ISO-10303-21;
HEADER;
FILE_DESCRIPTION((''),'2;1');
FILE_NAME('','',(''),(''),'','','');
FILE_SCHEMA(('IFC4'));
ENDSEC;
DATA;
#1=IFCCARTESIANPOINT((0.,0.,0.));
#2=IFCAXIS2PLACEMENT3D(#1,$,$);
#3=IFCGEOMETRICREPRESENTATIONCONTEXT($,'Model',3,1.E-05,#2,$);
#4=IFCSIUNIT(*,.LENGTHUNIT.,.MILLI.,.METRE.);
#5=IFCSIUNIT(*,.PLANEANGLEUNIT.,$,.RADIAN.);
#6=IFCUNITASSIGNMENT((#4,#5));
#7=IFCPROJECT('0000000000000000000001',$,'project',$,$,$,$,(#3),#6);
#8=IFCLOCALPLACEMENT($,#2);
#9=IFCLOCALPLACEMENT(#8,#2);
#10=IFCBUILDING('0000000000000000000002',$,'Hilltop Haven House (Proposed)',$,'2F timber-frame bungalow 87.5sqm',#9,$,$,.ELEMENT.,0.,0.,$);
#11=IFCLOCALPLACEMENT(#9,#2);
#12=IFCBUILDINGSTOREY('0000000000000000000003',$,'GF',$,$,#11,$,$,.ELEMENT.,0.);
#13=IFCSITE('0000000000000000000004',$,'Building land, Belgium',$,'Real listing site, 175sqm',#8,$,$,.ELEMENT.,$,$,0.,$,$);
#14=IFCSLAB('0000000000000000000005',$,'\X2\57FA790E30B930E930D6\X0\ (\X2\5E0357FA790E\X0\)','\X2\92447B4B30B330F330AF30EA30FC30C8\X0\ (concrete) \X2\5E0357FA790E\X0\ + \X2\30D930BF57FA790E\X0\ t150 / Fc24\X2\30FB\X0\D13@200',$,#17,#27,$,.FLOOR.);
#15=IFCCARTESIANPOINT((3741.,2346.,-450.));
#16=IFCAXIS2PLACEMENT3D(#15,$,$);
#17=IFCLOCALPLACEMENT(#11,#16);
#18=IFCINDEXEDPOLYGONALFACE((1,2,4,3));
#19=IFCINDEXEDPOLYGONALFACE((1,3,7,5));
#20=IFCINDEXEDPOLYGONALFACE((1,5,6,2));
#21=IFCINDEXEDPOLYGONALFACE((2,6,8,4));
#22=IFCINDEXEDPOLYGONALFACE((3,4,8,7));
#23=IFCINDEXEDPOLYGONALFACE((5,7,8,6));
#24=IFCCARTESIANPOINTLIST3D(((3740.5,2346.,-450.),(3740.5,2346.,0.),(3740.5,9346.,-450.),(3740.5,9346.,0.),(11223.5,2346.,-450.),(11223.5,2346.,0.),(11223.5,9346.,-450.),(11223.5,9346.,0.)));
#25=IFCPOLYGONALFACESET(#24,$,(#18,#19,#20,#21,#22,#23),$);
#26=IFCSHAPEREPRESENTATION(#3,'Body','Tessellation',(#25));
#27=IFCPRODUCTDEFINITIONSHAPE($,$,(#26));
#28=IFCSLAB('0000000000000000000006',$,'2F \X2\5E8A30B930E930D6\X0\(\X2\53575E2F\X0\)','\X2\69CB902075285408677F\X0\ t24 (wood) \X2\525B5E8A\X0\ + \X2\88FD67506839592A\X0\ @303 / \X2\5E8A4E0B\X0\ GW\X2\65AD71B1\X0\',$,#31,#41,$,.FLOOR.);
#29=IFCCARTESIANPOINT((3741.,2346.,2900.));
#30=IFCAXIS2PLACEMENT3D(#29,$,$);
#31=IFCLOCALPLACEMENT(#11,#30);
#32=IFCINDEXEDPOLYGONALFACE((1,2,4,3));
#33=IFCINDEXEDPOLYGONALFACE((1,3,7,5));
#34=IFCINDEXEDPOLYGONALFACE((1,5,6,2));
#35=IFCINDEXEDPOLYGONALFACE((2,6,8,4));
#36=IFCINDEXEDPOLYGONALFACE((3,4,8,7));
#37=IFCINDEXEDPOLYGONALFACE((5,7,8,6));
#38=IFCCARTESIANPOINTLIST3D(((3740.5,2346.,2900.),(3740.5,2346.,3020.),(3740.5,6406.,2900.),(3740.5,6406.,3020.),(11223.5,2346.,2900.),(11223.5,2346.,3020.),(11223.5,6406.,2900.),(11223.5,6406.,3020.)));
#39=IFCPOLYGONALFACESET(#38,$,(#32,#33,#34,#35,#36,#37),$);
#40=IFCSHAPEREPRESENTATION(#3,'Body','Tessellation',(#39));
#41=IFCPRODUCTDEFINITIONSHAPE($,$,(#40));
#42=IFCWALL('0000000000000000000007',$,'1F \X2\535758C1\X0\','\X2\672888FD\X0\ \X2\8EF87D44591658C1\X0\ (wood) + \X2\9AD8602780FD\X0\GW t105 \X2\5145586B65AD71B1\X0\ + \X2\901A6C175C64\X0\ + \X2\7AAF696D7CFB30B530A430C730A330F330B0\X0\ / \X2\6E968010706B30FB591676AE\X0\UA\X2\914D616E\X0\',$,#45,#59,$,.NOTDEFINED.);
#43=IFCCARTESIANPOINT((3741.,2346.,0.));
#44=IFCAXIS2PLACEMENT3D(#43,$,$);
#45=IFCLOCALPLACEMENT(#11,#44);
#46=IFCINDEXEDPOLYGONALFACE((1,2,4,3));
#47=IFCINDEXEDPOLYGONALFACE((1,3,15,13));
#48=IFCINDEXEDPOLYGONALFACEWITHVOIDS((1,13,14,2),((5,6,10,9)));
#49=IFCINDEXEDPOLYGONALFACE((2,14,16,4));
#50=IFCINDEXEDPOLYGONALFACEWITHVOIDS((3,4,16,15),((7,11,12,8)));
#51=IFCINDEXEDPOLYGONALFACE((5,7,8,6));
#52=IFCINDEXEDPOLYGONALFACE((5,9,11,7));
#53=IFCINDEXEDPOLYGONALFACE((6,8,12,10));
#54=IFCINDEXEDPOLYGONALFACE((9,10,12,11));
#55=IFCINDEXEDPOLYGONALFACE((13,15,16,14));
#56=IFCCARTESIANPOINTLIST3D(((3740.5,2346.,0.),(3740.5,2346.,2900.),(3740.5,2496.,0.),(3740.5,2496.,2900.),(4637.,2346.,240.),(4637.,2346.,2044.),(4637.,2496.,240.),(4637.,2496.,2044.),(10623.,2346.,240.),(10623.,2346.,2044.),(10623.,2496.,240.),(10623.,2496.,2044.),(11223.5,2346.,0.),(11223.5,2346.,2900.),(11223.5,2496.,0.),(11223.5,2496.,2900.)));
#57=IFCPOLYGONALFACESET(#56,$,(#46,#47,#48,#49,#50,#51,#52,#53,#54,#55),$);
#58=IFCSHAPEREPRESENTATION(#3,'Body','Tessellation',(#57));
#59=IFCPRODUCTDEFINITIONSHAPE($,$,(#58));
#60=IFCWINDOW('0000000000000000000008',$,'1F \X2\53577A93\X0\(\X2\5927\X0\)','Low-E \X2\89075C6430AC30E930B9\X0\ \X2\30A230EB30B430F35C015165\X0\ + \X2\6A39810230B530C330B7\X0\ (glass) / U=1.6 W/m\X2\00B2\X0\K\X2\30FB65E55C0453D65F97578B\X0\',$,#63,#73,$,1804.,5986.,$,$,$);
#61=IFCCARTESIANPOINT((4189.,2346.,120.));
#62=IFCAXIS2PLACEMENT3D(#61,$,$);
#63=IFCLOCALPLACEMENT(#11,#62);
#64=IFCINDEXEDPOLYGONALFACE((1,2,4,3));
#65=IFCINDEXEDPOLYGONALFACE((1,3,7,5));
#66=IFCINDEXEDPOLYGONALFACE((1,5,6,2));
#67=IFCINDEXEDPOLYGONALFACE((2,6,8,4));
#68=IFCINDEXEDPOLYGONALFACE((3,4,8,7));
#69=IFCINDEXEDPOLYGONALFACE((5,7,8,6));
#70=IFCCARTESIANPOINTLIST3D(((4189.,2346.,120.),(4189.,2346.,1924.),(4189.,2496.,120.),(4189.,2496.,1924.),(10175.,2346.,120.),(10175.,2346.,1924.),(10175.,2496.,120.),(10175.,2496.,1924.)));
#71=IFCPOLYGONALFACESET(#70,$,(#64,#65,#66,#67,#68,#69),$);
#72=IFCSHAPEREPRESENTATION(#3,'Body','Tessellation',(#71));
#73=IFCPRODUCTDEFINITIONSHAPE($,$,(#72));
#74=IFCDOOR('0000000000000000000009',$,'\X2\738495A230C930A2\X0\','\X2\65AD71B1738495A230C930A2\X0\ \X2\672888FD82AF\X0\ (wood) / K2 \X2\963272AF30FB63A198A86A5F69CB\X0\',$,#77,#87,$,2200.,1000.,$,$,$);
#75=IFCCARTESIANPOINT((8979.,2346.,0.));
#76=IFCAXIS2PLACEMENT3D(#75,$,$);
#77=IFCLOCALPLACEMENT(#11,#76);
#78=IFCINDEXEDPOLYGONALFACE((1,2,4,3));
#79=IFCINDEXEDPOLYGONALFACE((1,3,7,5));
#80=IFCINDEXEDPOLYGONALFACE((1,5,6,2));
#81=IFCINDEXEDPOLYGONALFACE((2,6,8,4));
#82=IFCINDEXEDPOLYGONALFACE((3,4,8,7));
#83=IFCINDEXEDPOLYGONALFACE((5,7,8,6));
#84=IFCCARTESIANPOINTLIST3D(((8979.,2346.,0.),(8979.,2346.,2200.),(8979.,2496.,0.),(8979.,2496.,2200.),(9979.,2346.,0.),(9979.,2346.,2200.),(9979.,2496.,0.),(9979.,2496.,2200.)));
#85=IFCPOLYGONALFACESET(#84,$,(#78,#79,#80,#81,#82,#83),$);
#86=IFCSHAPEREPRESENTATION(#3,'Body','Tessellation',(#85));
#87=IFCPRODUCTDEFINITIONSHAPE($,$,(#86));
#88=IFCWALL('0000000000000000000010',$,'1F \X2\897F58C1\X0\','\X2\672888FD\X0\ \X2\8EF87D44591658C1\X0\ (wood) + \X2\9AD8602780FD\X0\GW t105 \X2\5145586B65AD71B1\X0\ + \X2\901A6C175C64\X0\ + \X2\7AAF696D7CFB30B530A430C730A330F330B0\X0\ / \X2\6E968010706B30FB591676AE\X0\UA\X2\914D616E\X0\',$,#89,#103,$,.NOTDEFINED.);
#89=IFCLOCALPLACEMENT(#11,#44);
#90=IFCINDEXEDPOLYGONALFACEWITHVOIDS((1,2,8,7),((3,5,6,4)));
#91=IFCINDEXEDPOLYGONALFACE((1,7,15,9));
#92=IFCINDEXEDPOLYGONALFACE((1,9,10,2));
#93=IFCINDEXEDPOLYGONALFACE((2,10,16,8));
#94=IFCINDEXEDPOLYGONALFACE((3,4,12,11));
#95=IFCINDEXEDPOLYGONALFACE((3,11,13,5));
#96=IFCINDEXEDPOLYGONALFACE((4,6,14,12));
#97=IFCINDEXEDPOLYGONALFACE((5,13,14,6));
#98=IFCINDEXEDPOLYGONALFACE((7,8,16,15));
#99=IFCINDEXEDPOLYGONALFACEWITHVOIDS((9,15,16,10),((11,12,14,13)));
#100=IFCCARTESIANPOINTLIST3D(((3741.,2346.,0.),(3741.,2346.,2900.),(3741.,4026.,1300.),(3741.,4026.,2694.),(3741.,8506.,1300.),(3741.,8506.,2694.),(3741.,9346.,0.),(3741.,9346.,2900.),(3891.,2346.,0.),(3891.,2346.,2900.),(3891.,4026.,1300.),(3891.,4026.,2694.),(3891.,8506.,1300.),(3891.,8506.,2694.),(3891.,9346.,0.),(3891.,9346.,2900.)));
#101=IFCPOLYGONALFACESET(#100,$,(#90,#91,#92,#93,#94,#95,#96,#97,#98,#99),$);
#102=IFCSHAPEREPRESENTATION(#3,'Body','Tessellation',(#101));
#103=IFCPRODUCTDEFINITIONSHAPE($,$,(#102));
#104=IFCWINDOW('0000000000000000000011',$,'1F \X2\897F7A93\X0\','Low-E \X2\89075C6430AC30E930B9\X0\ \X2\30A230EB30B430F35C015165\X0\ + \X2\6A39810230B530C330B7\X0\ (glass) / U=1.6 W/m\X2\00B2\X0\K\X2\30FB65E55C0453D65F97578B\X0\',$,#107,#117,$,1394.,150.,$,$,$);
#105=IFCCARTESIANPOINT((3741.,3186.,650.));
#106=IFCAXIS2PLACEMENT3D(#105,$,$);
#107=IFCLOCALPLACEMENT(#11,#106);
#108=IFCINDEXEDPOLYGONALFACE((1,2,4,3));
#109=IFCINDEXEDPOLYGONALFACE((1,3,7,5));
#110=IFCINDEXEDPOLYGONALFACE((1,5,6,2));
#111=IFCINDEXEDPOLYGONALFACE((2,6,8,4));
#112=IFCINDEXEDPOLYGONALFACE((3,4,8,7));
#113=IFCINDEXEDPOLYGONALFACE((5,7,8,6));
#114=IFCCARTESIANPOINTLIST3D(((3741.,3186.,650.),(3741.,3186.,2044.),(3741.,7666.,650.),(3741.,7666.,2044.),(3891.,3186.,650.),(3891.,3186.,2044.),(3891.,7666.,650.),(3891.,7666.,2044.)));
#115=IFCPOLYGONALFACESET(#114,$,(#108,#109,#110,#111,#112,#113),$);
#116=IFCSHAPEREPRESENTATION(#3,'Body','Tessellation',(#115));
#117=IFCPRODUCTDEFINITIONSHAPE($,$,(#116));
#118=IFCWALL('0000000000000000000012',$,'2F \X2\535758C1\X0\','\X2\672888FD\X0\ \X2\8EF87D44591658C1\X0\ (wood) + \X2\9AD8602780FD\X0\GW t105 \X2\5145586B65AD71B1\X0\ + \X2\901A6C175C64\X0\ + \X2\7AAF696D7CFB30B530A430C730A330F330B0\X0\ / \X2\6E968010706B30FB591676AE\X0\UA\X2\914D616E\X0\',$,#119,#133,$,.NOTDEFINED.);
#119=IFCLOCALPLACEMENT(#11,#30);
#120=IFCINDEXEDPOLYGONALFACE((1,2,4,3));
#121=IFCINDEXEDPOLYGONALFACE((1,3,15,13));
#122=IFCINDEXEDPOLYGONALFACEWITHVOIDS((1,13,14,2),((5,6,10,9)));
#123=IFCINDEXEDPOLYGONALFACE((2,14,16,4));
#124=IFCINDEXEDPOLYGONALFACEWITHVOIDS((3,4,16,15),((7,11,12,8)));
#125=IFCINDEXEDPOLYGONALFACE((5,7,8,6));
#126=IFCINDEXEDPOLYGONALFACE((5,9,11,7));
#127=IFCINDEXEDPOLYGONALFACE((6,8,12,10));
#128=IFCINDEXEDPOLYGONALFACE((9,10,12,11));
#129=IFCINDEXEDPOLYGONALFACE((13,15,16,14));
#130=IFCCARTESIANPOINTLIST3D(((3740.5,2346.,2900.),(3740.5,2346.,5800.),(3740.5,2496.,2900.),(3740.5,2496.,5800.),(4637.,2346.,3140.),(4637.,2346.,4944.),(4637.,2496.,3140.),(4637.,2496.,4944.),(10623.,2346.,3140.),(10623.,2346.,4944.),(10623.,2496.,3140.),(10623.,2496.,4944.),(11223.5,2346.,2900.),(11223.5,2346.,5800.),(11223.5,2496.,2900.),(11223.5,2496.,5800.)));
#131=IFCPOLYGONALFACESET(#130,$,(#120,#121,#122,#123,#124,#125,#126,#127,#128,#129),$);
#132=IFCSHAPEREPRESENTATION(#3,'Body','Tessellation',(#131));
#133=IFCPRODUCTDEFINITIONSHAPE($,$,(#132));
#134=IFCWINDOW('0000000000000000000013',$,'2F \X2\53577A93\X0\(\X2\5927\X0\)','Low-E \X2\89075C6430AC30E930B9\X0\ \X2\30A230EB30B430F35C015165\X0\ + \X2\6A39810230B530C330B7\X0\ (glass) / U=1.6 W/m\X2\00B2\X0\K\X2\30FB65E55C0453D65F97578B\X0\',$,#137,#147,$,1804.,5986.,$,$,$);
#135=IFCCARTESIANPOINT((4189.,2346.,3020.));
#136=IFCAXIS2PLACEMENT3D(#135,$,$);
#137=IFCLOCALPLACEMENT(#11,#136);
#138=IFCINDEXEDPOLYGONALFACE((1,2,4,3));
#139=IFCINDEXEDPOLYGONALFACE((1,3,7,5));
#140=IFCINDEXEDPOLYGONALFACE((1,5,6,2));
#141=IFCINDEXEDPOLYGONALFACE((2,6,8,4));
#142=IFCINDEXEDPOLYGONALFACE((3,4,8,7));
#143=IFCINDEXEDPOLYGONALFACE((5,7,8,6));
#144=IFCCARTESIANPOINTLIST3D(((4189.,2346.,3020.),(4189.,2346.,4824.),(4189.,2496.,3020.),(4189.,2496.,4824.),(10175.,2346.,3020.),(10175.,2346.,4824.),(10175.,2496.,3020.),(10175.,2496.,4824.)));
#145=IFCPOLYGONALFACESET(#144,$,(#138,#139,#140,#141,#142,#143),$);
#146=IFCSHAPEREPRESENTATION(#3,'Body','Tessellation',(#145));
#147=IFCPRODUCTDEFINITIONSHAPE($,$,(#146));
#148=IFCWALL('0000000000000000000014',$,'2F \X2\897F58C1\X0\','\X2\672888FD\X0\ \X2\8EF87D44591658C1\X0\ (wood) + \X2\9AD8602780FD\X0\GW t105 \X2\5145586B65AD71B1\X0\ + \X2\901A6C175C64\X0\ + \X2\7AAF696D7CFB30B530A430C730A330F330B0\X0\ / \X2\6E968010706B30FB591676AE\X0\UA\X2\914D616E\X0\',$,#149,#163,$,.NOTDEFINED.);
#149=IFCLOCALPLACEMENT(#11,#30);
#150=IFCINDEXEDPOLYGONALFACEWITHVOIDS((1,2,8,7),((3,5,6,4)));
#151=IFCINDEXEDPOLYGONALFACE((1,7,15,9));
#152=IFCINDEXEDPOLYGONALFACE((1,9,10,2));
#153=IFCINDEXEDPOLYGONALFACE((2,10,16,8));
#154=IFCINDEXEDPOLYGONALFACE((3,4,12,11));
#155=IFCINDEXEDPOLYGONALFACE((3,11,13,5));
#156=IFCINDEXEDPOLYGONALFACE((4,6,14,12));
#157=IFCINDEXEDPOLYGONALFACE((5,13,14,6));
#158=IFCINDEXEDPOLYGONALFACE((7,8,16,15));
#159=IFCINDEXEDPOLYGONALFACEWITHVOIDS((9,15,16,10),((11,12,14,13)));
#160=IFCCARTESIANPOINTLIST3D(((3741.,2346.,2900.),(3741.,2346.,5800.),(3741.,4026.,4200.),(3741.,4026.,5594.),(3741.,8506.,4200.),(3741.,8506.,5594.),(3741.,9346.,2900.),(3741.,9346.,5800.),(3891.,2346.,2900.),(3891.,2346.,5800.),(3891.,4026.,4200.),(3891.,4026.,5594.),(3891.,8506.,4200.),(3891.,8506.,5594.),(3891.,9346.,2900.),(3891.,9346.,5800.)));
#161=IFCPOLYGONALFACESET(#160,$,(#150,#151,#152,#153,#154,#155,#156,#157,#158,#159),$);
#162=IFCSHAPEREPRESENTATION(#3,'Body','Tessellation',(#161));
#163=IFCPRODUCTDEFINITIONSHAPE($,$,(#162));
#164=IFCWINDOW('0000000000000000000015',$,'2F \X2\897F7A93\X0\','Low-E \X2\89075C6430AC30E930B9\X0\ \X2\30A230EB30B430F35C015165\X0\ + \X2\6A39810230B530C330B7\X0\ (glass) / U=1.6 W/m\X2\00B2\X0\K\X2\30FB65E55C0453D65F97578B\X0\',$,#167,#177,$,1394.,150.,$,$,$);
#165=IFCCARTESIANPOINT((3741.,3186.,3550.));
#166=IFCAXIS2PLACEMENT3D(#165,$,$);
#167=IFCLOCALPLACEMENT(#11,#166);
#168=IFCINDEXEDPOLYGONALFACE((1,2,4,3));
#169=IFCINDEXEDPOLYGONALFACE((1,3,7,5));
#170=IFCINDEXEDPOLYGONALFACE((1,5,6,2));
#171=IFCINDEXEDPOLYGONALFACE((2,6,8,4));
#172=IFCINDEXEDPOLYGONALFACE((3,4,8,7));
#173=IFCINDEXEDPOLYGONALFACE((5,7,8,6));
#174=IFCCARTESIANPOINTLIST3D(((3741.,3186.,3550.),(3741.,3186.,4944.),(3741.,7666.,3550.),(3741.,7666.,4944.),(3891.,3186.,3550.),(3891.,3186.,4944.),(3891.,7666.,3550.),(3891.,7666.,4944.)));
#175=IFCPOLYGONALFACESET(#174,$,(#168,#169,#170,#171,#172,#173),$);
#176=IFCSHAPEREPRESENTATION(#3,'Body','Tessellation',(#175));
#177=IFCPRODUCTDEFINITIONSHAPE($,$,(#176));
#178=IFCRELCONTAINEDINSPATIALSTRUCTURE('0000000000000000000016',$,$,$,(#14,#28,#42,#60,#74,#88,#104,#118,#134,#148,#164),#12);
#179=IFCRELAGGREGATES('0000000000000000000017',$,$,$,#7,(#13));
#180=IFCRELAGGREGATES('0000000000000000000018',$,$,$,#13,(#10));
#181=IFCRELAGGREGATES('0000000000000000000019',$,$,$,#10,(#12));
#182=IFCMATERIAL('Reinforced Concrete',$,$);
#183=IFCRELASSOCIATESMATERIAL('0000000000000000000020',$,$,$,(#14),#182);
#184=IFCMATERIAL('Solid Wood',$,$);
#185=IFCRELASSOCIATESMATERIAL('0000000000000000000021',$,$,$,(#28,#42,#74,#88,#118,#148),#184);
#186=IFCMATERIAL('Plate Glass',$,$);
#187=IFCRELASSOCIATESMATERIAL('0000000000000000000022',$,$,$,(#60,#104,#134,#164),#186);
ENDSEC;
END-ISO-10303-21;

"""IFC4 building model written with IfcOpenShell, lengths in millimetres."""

from ifc_helpers import new_model, si_unit, frame, frame_2d, origin, place, context, project, spatial, rectangle, extrude, material, element, fill, save


model = new_model("IFC4")

# Units and contexts
model_context = context("Model", 3, precision=1e-05, world=origin())
ifc_project = project(units=[si_unit("LENGTHUNIT", "METRE", prefix="MILLI"), si_unit("PLANEANGLEUNIT", "RADIAN")], contexts=[model_context])

# Site, building, storey
site_placement = place(None, origin())
site = spatial("IfcSite", under=ifc_project, at=site_placement, Name="Building land, Belgium", ObjectType="Real listing site, 175sqm", CompositionType="ELEMENT", RefElevation=0.0)
building_placement = place(site_placement, origin())
building = spatial("IfcBuilding", under=site, at=building_placement, Name="Hilltop Haven House (Proposed)", ObjectType="2F timber-frame bungalow 87.5sqm", CompositionType="ELEMENT", ElevationOfRefHeight=0.0, ElevationOfTerrain=0.0)
storey_placement = place(building_placement, origin())
storey = spatial("IfcBuildingStorey", under=building, at=storey_placement, Name="GF", CompositionType="ELEMENT", Elevation=0.0)

# Slabs
ifc_material_1 = material(Name="Reinforced Concrete")
slab_1_placement = place(storey_placement, frame((3741.0, 2346.0, -450.0)))
element("IfcSlab", 1, at=slab_1_placement, inside=storey, material=ifc_material_1, Name="基礎スラブ (布基礎)", Description="鉄筋コンクリート (concrete) 布基礎 + ベタ基礎 t150 / Fc24・D13@200", PredefinedType="FLOOR", context=model_context, shape_type="SweptSolid", body=[
    extrude(rectangle(XDim=7483.0, YDim=7000.0, at=frame_2d((3741.0, 3500.0))), frame((3741.0, 2346.0, -450.0)), (0.0, 0.0, 1.0), 450.0),
])
ifc_material_2 = material(Name="Solid Wood")
slab_2_placement = place(storey_placement, frame((3741.0, 2346.0, 2900.0)))
element("IfcSlab", 2, at=slab_2_placement, inside=storey, material=ifc_material_2, Name="2F 床スラブ(南帯)", Description="構造用合板 t24 (wood) 剛床 + 製材根太 @303 / 床下 GW断熱", PredefinedType="FLOOR", context=model_context, shape_type="SweptSolid", body=[
    extrude(rectangle(XDim=7483.0, YDim=4060.0, at=frame_2d((3741.0, 2030.0))), frame((3741.0, 2346.0, 2900.0)), (0.0, 0.0, 1.0), 120.0),
])

# Wall, openings, window, door
wall_1_placement = place(storey_placement, frame((3741.0, 2346.0, 0.0)))
wall_1 = element("IfcWall", 3, at=wall_1_placement, inside=storey, material=ifc_material_2, Name="1F 南壁", Description="木製 軸組外壁 (wood) + 高性能GW t105 充填断熱 + 通気層 + 窯業系サイディング / 準耐火・外皮UA配慮", PredefinedType="NOTDEFINED", context=model_context, shape_type="SweptSolid", body=[
    extrude(rectangle(XDim=7483.0, YDim=150.0, at=frame_2d((3741.0, 75.0))), frame((3741.0, 2346.0, 0.0)), (0.0, 0.0, 1.0), 2900.0),
])
opening_1_placement = place(storey_placement, frame((4189.0, 2346.0, 120.0)))
opening_1 = element("IfcOpeningElement", 4, at=opening_1_placement, cuts=wall_1, PredefinedType="NOTDEFINED", context=model_context, shape_type="SweptSolid", body=[
    extrude(rectangle(XDim=5986.0, YDim=150.0, at=frame_2d((2993.0, 75.0))), frame((4189.0, 2346.0, 120.0)), (0.0, 0.0, 1.0), 1804.0),
])
opening_2_placement = place(storey_placement, frame((8979.0, 2346.0, 0.0)))
opening_2 = element("IfcOpeningElement", 5, at=opening_2_placement, cuts=wall_1, PredefinedType="NOTDEFINED", context=model_context, shape_type="SweptSolid", body=[
    extrude(rectangle(XDim=1000.0, YDim=150.0, at=frame_2d((500.0, 75.0))), frame((8979.0, 2346.0, 0.0)), (0.0, 0.0, 1.0), 2200.0),
])
ifc_material_3 = material(Name="Plate Glass")
window_1_placement = place(storey_placement, frame((4189.0, 2346.0, 120.0)))
window_1 = element("IfcWindow", 6, at=window_1_placement, inside=storey, material=ifc_material_3, Name="1F 南窓(大)", Description="Low-E 複層ガラス アルゴン封入 + 樹脂サッシ (glass) / U=1.6 W/m²K・日射取得型", OverallHeight=1804.0, OverallWidth=5986.0, context=model_context, shape_type="SweptSolid", body=[
    extrude(rectangle(XDim=5986.0, YDim=150.0, at=frame_2d((2993.0, 75.0))), frame((4189.0, 2346.0, 120.0)), (0.0, 0.0, 1.0), 1804.0),
])
fill(opening_1, window_1)
door_placement = place(storey_placement, frame((8979.0, 2346.0, 0.0)))
door = element("IfcDoor", 7, at=door_placement, inside=storey, material=ifc_material_2, Name="玄関ドア", Description="断熱玄関ドア 木製芯 (wood) / K2 防犯・採風機構", OverallHeight=2200.0, OverallWidth=1000.0, context=model_context, shape_type="SweptSolid", body=[
    extrude(rectangle(XDim=1000.0, YDim=150.0, at=frame_2d((500.0, 75.0))), frame((8979.0, 2346.0, 0.0)), (0.0, 0.0, 1.0), 2200.0),
])
fill(opening_2, door)

# Wall, opening, window
wall_2_placement = place(storey_placement, frame((3741.0, 2346.0, 0.0)))
wall_2 = element("IfcWall", 8, at=wall_2_placement, inside=storey, material=ifc_material_2, Name="1F 西壁", Description="木製 軸組外壁 (wood) + 高性能GW t105 充填断熱 + 通気層 + 窯業系サイディング / 準耐火・外皮UA配慮", PredefinedType="NOTDEFINED", context=model_context, shape_type="SweptSolid", body=[
    extrude(rectangle(XDim=150.0, YDim=7000.0, at=frame_2d((75.0, 3500.0))), frame((3741.0, 2346.0, 0.0)), (0.0, 0.0, 1.0), 2900.0),
])
opening_3_placement = place(storey_placement, frame((3741.0, 3186.0, 650.0)))
opening_3 = element("IfcOpeningElement", 9, at=opening_3_placement, cuts=wall_2, PredefinedType="NOTDEFINED", context=model_context, shape_type="SweptSolid", body=[
    extrude(rectangle(XDim=150.0, YDim=4480.0, at=frame_2d((75.0, 2240.0))), frame((3741.0, 3186.0, 650.0)), (0.0, 0.0, 1.0), 1394.0),
])
window_2_placement = place(storey_placement, frame((3741.0, 3186.0, 650.0)))
window_2 = element("IfcWindow", 10, at=window_2_placement, inside=storey, material=ifc_material_3, Name="1F 西窓", Description="Low-E 複層ガラス アルゴン封入 + 樹脂サッシ (glass) / U=1.6 W/m²K・日射取得型", OverallHeight=1394.0, OverallWidth=150.0, context=model_context, shape_type="SweptSolid", body=[
    extrude(rectangle(XDim=150.0, YDim=4480.0, at=frame_2d((75.0, 2240.0))), frame((3741.0, 3186.0, 650.0)), (0.0, 0.0, 1.0), 1394.0),
])
fill(opening_3, window_2)

# Walls, openings, windows
wall_3_placement = place(storey_placement, frame((3741.0, 2346.0, 2900.0)))
wall_3 = element("IfcWall", 11, at=wall_3_placement, inside=storey, material=ifc_material_2, Name="2F 南壁", Description="木製 軸組外壁 (wood) + 高性能GW t105 充填断熱 + 通気層 + 窯業系サイディング / 準耐火・外皮UA配慮", PredefinedType="NOTDEFINED", context=model_context, shape_type="SweptSolid", body=[
    extrude(rectangle(XDim=7483.0, YDim=150.0, at=frame_2d((3741.0, 75.0))), frame((3741.0, 2346.0, 2900.0)), (0.0, 0.0, 1.0), 2900.0),
])
opening_4_placement = place(storey_placement, frame((4189.0, 2346.0, 3020.0)))
opening_4 = element("IfcOpeningElement", 12, at=opening_4_placement, cuts=wall_3, PredefinedType="NOTDEFINED", context=model_context, shape_type="SweptSolid", body=[
    extrude(rectangle(XDim=5986.0, YDim=150.0, at=frame_2d((2993.0, 75.0))), frame((4189.0, 2346.0, 3020.0)), (0.0, 0.0, 1.0), 1804.0),
])
window_3_placement = place(storey_placement, frame((4189.0, 2346.0, 3020.0)))
window_3 = element("IfcWindow", 13, at=window_3_placement, inside=storey, material=ifc_material_3, Name="2F 南窓(大)", Description="Low-E 複層ガラス アルゴン封入 + 樹脂サッシ (glass) / U=1.6 W/m²K・日射取得型", OverallHeight=1804.0, OverallWidth=5986.0, context=model_context, shape_type="SweptSolid", body=[
    extrude(rectangle(XDim=5986.0, YDim=150.0, at=frame_2d((2993.0, 75.0))), frame((4189.0, 2346.0, 3020.0)), (0.0, 0.0, 1.0), 1804.0),
])
fill(opening_4, window_3)
wall_4_placement = place(storey_placement, frame((3741.0, 2346.0, 2900.0)))
wall_4 = element("IfcWall", 14, at=wall_4_placement, inside=storey, material=ifc_material_2, Name="2F 西壁", Description="木製 軸組外壁 (wood) + 高性能GW t105 充填断熱 + 通気層 + 窯業系サイディング / 準耐火・外皮UA配慮", PredefinedType="NOTDEFINED", context=model_context, shape_type="SweptSolid", body=[
    extrude(rectangle(XDim=150.0, YDim=7000.0, at=frame_2d((75.0, 3500.0))), frame((3741.0, 2346.0, 2900.0)), (0.0, 0.0, 1.0), 2900.0),
])
opening_5_placement = place(storey_placement, frame((3741.0, 3186.0, 3550.0)))
opening_5 = element("IfcOpeningElement", 15, at=opening_5_placement, cuts=wall_4, PredefinedType="NOTDEFINED", context=model_context, shape_type="SweptSolid", body=[
    extrude(rectangle(XDim=150.0, YDim=4480.0, at=frame_2d((75.0, 2240.0))), frame((3741.0, 3186.0, 3550.0)), (0.0, 0.0, 1.0), 1394.0),
])
window_4_placement = place(storey_placement, frame((3741.0, 3186.0, 3550.0)))
window_4 = element("IfcWindow", 16, at=window_4_placement, inside=storey, material=ifc_material_3, Name="2F 西窓", Description="Low-E 複層ガラス アルゴン封入 + 樹脂サッシ (glass) / U=1.6 W/m²K・日射取得型", OverallHeight=1394.0, OverallWidth=150.0, context=model_context, shape_type="SweptSolid", body=[
    extrude(rectangle(XDim=150.0, YDim=4480.0, at=frame_2d((75.0, 2240.0))), frame((3741.0, 3186.0, 3550.0)), (0.0, 0.0, 1.0), 1394.0),
])
fill(opening_5, window_4)

save(model, "model.ifc")
